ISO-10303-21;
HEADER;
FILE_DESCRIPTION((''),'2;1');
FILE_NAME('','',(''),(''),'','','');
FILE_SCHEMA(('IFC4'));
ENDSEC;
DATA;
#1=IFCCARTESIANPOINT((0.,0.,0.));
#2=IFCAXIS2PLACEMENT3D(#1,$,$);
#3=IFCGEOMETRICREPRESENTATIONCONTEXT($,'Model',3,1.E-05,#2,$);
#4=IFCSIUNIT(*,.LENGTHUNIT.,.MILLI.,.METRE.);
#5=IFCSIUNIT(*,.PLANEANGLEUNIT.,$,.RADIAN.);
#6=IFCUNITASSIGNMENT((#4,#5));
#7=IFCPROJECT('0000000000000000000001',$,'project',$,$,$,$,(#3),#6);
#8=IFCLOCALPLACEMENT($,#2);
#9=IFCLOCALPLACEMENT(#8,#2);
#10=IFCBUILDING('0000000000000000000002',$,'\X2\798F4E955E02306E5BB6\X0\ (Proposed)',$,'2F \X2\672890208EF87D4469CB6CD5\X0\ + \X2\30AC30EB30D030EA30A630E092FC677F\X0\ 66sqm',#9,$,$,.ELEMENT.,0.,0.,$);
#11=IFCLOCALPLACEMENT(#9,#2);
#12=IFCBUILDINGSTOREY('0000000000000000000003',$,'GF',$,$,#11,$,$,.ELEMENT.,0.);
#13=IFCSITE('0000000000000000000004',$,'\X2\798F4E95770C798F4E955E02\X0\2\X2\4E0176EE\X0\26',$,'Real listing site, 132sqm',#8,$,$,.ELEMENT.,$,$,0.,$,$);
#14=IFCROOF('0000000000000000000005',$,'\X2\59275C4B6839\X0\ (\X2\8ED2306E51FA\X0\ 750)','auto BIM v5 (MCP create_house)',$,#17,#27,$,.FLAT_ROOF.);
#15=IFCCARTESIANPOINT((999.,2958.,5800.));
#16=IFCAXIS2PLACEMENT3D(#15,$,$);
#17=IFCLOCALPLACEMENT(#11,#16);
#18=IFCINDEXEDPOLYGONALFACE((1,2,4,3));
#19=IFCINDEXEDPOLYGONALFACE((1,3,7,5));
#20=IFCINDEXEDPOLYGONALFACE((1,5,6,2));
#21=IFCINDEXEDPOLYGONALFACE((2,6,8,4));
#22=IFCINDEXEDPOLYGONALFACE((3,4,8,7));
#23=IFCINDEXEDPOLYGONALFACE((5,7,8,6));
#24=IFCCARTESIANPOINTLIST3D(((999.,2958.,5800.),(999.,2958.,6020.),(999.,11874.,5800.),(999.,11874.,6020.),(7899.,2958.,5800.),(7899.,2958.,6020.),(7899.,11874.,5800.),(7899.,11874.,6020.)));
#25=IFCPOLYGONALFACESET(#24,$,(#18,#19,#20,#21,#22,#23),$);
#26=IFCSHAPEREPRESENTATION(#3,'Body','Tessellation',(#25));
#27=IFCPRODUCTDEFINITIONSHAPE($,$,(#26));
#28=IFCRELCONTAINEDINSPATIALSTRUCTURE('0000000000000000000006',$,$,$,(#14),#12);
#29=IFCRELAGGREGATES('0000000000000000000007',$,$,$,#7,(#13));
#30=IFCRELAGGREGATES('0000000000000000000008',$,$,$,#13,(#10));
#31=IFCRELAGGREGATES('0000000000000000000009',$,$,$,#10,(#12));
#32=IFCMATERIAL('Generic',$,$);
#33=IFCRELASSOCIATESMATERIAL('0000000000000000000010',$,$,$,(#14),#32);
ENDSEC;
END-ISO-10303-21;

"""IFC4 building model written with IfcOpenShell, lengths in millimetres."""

from ifc_helpers import new_model, si_unit, frame, frame_2d, origin, place, context, project, spatial, rectangle, extrude, material, element, save


model = new_model("IFC4")

# Units and contexts
model_context = context("Model", 3, precision=1e-05, world=origin())
ifc_project = project(units=[si_unit("LENGTHUNIT", "METRE", prefix="MILLI"), si_unit("PLANEANGLEUNIT", "RADIAN")], contexts=[model_context])

# Site, building, storey
site_placement = place(None, origin())
site = spatial("IfcSite", under=ifc_project, at=site_placement, Name="福井県福井市2丁目26", ObjectType="Real listing site, 132sqm", CompositionType="ELEMENT", RefElevation=0.0)
building_placement = place(site_placement, origin())
building = spatial("IfcBuilding", under=site, at=building_placement, Name="福井市の家 (Proposed)", ObjectType="2F 木造軸組構法 + ガルバリウム鋼板 66sqm", CompositionType="ELEMENT", ElevationOfRefHeight=0.0, ElevationOfTerrain=0.0)
storey_placement = place(building_placement, origin())
storey = spatial("IfcBuildingStorey", under=building, at=storey_placement, Name="GF", CompositionType="ELEMENT", Elevation=0.0)

# Shared definitions
ifc_material = material(Name="Generic")

# Roof
roof_placement = place(storey_placement, frame((999.0, 2958.0, 5800.0)))
element("IfcRoof", 1, at=roof_placement, inside=storey, material=ifc_material, Name="大屋根 (軒の出 750)", Description="auto BIM v5 (MCP create_house)", PredefinedType="FLAT_ROOF", context=model_context, shape_type="SweptSolid", body=[
    extrude(rectangle(XDim=6900.0, YDim=8916.0, at=frame_2d((3450.0, 4458.0))), frame((999.0, 2958.0, 5800.0)), (0.0, 0.0, 1.0), 220.0),
])

save(model, "model.ifc")
